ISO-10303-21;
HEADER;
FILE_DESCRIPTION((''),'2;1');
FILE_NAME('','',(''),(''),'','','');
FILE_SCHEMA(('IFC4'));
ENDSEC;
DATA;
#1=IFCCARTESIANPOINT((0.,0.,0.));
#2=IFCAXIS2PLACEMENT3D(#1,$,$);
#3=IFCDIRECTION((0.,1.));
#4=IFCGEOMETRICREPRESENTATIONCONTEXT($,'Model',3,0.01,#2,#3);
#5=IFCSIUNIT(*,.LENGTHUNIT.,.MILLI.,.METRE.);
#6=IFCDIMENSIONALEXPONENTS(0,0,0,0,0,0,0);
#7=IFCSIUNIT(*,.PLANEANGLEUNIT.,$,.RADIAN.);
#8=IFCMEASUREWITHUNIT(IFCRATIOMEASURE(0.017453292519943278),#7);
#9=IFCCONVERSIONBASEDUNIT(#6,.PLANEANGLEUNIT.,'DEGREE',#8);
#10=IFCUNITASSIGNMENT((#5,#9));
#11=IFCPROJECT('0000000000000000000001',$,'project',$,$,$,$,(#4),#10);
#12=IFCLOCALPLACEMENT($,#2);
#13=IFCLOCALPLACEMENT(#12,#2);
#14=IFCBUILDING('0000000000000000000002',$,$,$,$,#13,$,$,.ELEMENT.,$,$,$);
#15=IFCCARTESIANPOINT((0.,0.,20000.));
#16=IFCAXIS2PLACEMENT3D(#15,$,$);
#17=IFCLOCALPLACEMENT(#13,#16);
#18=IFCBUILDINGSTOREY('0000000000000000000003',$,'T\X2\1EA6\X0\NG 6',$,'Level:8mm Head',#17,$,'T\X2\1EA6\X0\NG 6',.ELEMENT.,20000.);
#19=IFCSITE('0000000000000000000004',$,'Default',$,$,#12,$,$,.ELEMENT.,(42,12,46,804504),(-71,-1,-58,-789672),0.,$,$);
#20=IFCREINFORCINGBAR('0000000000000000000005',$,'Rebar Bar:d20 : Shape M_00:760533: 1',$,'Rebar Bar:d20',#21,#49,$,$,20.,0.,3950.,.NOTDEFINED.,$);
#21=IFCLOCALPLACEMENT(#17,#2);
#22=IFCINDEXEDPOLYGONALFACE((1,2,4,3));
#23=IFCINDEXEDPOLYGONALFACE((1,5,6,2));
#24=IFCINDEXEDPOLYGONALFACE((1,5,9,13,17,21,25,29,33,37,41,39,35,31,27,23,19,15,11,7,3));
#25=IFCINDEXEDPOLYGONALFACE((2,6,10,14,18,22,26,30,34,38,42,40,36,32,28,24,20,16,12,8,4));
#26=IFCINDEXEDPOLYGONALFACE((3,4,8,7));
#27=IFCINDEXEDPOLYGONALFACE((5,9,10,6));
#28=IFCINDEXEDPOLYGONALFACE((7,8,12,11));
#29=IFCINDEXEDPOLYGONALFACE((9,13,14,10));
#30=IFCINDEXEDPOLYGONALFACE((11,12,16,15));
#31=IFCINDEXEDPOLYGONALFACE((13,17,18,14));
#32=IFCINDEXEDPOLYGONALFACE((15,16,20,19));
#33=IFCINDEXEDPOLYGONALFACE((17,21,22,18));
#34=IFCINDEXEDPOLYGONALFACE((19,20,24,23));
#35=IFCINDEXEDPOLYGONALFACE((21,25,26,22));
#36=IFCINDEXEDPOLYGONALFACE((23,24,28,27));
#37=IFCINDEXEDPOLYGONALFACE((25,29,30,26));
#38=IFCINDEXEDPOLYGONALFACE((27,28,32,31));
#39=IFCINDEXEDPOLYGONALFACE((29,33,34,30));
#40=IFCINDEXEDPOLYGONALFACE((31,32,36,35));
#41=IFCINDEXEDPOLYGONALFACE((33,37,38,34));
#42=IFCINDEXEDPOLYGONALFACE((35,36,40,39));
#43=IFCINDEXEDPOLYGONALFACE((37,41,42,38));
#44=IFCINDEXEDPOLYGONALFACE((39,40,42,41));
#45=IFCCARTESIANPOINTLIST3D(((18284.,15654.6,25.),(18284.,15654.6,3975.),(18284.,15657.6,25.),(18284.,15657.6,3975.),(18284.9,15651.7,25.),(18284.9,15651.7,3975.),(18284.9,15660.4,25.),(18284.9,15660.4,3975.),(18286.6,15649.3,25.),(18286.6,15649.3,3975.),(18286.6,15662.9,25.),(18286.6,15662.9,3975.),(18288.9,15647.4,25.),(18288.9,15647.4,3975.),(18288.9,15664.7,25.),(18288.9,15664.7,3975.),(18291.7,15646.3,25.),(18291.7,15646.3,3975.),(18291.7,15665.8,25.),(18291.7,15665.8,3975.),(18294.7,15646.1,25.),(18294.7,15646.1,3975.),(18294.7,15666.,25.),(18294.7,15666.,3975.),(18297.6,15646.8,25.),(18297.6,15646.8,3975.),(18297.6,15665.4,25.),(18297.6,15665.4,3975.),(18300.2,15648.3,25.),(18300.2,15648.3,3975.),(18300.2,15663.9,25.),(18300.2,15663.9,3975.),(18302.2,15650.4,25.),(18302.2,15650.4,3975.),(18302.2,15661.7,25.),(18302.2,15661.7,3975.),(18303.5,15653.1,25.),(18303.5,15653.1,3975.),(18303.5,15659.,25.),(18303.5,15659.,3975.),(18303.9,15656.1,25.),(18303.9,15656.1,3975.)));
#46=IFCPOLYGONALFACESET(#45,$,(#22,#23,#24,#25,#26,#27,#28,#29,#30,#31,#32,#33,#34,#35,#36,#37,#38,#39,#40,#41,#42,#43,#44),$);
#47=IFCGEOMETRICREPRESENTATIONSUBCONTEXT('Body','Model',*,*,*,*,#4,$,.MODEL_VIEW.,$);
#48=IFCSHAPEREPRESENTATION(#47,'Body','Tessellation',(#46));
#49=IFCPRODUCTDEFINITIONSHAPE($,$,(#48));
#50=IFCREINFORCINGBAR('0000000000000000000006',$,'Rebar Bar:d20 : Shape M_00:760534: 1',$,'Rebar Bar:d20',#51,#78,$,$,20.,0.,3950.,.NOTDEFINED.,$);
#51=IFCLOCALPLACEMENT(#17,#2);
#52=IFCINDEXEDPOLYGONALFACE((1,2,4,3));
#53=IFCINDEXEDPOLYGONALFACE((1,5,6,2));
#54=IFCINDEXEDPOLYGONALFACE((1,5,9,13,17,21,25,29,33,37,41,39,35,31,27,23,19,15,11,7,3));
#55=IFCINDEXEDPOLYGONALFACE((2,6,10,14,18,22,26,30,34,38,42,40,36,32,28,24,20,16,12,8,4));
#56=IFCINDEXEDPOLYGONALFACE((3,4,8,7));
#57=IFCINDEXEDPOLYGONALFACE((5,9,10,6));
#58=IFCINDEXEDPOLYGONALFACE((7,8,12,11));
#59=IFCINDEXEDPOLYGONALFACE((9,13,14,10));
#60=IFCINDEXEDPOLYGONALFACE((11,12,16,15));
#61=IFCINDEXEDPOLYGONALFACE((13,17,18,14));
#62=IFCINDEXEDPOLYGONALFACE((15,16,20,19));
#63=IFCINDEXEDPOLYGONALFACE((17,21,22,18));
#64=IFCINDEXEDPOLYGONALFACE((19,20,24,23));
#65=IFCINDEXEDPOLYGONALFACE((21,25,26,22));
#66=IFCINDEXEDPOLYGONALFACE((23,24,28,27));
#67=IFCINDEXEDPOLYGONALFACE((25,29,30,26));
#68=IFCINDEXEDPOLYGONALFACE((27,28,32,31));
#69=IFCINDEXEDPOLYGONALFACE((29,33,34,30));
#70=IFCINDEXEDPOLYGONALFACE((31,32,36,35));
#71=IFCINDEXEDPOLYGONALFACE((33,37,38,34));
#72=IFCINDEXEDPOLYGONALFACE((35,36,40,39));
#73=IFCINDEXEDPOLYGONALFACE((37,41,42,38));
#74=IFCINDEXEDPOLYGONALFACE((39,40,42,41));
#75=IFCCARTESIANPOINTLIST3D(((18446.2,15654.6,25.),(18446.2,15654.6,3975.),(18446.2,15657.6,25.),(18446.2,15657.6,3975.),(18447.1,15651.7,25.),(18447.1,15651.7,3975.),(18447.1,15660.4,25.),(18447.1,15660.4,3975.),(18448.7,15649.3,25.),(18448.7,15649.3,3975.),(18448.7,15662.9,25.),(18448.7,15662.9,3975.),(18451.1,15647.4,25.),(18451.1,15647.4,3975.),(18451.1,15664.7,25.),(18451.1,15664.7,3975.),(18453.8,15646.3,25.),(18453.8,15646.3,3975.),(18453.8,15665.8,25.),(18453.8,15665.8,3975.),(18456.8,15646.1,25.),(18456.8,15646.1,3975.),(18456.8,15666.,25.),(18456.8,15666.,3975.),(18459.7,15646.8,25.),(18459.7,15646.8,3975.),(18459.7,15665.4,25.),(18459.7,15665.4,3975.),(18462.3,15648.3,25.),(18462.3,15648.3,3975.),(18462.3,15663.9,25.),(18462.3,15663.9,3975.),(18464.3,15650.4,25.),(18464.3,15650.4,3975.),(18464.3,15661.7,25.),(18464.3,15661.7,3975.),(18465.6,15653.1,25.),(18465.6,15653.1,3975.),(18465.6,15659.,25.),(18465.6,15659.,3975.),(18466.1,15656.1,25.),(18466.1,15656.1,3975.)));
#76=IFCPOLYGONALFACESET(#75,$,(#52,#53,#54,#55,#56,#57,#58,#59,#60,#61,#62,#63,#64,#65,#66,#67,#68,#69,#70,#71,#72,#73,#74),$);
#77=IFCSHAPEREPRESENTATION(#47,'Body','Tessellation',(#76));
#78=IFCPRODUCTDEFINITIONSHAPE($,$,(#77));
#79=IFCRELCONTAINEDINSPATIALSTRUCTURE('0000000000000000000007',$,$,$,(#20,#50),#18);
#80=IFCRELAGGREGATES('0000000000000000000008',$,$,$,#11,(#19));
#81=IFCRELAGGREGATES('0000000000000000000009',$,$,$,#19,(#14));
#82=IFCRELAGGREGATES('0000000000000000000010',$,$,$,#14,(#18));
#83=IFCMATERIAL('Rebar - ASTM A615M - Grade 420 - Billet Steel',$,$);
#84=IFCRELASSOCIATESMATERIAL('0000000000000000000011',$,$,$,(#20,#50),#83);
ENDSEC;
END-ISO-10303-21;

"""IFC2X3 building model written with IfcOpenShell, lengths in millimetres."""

from ifc_helpers import new_model, entity, si_unit, converted_unit, direction, frame, origin, place, context, subcontext, project, spatial, material, element, save


model = new_model("IFC2X3")

# Units and contexts
model_context = context("Model", 3, precision=0.01, world=origin(), true_north=direction((0.0, 1.0)))
body_context = subcontext(model_context, "Body", "Model", "MODEL_VIEW")
ifc_project = project(units=[si_unit("LENGTHUNIT", "METRE", prefix="MILLI"), converted_unit("PLANEANGLEUNIT", "DEGREE", entity("IfcRatioMeasure", 0.017453292519943278), si_unit("PLANEANGLEUNIT", "RADIAN"), dimensions=[0, 0, 0, 0, 0, 0, 0])], contexts=[model_context])

# Site, building, storey
site_placement = place(None, origin())
site = spatial("IfcSite", under=ifc_project, at=site_placement, Name="Default", CompositionType="ELEMENT", RefLatitude=(42, 12, 46, 804504), RefLongitude=(-71, -1, -58, -789672), RefElevation=0.0)
building_placement = place(site_placement, origin())
building = spatial("IfcBuilding", under=site, at=building_placement, CompositionType="ELEMENT")
storey_placement = place(building_placement, frame((0.0, 0.0, 20000.0)))
storey = spatial("IfcBuildingStorey", under=building, at=storey_placement, Name="TẦNG 6", ObjectType="Level:8mm Head", LongName="TẦNG 6", CompositionType="ELEMENT", Elevation=20000.0)

# Reinforcing bars
ifc_material = material(Name="Rebar - ASTM A615M - Grade 420 - Billet Steel")
reinforcing_bar_1_placement = place(storey_placement, origin())
element("IfcReinforcingBar", 1, at=reinforcing_bar_1_placement, inside=storey, material=ifc_material, Name="Rebar Bar:d20 : Shape M_00:760533: 1", ObjectType="Rebar Bar:d20", BarLength=3950.0, BarRole="NOTDEFINED", CrossSectionArea=0.0, NominalDiameter=20.0, context=body_context, shape_type="AdvancedSweptSolid", body=[
    entity("IfcSweptDiskSolid", entity("IfcCompositeCurve", [entity("IfcCompositeCurveSegment", "CONTINUOUS", True, entity("IfcPolyline", [entity("IfcCartesianPoint", [18293.9, 15656.1, 25.0]), entity("IfcCartesianPoint", [18293.9, 15656.1, 3975.0])]))], False), 10.0, None, 0.0, 1.0),
])
reinforcing_bar_2_placement = place(storey_placement, origin())
element("IfcReinforcingBar", 2, at=reinforcing_bar_2_placement, inside=storey, material=ifc_material, Name="Rebar Bar:d20 : Shape M_00:760534: 1", ObjectType="Rebar Bar:d20", BarLength=3950.0, BarRole="NOTDEFINED", CrossSectionArea=0.0, NominalDiameter=20.0, context=body_context, shape_type="AdvancedSweptSolid", body=[
    entity("IfcSweptDiskSolid", entity("IfcCompositeCurve", [entity("IfcCompositeCurveSegment", "CONTINUOUS", True, entity("IfcPolyline", [entity("IfcCartesianPoint", [18456.1, 15656.1, 25.0]), entity("IfcCartesianPoint", [18456.1, 15656.1, 3975.0])]))], False), 10.0, None, 0.0, 1.0),
])

save(model, "model.ifc")
